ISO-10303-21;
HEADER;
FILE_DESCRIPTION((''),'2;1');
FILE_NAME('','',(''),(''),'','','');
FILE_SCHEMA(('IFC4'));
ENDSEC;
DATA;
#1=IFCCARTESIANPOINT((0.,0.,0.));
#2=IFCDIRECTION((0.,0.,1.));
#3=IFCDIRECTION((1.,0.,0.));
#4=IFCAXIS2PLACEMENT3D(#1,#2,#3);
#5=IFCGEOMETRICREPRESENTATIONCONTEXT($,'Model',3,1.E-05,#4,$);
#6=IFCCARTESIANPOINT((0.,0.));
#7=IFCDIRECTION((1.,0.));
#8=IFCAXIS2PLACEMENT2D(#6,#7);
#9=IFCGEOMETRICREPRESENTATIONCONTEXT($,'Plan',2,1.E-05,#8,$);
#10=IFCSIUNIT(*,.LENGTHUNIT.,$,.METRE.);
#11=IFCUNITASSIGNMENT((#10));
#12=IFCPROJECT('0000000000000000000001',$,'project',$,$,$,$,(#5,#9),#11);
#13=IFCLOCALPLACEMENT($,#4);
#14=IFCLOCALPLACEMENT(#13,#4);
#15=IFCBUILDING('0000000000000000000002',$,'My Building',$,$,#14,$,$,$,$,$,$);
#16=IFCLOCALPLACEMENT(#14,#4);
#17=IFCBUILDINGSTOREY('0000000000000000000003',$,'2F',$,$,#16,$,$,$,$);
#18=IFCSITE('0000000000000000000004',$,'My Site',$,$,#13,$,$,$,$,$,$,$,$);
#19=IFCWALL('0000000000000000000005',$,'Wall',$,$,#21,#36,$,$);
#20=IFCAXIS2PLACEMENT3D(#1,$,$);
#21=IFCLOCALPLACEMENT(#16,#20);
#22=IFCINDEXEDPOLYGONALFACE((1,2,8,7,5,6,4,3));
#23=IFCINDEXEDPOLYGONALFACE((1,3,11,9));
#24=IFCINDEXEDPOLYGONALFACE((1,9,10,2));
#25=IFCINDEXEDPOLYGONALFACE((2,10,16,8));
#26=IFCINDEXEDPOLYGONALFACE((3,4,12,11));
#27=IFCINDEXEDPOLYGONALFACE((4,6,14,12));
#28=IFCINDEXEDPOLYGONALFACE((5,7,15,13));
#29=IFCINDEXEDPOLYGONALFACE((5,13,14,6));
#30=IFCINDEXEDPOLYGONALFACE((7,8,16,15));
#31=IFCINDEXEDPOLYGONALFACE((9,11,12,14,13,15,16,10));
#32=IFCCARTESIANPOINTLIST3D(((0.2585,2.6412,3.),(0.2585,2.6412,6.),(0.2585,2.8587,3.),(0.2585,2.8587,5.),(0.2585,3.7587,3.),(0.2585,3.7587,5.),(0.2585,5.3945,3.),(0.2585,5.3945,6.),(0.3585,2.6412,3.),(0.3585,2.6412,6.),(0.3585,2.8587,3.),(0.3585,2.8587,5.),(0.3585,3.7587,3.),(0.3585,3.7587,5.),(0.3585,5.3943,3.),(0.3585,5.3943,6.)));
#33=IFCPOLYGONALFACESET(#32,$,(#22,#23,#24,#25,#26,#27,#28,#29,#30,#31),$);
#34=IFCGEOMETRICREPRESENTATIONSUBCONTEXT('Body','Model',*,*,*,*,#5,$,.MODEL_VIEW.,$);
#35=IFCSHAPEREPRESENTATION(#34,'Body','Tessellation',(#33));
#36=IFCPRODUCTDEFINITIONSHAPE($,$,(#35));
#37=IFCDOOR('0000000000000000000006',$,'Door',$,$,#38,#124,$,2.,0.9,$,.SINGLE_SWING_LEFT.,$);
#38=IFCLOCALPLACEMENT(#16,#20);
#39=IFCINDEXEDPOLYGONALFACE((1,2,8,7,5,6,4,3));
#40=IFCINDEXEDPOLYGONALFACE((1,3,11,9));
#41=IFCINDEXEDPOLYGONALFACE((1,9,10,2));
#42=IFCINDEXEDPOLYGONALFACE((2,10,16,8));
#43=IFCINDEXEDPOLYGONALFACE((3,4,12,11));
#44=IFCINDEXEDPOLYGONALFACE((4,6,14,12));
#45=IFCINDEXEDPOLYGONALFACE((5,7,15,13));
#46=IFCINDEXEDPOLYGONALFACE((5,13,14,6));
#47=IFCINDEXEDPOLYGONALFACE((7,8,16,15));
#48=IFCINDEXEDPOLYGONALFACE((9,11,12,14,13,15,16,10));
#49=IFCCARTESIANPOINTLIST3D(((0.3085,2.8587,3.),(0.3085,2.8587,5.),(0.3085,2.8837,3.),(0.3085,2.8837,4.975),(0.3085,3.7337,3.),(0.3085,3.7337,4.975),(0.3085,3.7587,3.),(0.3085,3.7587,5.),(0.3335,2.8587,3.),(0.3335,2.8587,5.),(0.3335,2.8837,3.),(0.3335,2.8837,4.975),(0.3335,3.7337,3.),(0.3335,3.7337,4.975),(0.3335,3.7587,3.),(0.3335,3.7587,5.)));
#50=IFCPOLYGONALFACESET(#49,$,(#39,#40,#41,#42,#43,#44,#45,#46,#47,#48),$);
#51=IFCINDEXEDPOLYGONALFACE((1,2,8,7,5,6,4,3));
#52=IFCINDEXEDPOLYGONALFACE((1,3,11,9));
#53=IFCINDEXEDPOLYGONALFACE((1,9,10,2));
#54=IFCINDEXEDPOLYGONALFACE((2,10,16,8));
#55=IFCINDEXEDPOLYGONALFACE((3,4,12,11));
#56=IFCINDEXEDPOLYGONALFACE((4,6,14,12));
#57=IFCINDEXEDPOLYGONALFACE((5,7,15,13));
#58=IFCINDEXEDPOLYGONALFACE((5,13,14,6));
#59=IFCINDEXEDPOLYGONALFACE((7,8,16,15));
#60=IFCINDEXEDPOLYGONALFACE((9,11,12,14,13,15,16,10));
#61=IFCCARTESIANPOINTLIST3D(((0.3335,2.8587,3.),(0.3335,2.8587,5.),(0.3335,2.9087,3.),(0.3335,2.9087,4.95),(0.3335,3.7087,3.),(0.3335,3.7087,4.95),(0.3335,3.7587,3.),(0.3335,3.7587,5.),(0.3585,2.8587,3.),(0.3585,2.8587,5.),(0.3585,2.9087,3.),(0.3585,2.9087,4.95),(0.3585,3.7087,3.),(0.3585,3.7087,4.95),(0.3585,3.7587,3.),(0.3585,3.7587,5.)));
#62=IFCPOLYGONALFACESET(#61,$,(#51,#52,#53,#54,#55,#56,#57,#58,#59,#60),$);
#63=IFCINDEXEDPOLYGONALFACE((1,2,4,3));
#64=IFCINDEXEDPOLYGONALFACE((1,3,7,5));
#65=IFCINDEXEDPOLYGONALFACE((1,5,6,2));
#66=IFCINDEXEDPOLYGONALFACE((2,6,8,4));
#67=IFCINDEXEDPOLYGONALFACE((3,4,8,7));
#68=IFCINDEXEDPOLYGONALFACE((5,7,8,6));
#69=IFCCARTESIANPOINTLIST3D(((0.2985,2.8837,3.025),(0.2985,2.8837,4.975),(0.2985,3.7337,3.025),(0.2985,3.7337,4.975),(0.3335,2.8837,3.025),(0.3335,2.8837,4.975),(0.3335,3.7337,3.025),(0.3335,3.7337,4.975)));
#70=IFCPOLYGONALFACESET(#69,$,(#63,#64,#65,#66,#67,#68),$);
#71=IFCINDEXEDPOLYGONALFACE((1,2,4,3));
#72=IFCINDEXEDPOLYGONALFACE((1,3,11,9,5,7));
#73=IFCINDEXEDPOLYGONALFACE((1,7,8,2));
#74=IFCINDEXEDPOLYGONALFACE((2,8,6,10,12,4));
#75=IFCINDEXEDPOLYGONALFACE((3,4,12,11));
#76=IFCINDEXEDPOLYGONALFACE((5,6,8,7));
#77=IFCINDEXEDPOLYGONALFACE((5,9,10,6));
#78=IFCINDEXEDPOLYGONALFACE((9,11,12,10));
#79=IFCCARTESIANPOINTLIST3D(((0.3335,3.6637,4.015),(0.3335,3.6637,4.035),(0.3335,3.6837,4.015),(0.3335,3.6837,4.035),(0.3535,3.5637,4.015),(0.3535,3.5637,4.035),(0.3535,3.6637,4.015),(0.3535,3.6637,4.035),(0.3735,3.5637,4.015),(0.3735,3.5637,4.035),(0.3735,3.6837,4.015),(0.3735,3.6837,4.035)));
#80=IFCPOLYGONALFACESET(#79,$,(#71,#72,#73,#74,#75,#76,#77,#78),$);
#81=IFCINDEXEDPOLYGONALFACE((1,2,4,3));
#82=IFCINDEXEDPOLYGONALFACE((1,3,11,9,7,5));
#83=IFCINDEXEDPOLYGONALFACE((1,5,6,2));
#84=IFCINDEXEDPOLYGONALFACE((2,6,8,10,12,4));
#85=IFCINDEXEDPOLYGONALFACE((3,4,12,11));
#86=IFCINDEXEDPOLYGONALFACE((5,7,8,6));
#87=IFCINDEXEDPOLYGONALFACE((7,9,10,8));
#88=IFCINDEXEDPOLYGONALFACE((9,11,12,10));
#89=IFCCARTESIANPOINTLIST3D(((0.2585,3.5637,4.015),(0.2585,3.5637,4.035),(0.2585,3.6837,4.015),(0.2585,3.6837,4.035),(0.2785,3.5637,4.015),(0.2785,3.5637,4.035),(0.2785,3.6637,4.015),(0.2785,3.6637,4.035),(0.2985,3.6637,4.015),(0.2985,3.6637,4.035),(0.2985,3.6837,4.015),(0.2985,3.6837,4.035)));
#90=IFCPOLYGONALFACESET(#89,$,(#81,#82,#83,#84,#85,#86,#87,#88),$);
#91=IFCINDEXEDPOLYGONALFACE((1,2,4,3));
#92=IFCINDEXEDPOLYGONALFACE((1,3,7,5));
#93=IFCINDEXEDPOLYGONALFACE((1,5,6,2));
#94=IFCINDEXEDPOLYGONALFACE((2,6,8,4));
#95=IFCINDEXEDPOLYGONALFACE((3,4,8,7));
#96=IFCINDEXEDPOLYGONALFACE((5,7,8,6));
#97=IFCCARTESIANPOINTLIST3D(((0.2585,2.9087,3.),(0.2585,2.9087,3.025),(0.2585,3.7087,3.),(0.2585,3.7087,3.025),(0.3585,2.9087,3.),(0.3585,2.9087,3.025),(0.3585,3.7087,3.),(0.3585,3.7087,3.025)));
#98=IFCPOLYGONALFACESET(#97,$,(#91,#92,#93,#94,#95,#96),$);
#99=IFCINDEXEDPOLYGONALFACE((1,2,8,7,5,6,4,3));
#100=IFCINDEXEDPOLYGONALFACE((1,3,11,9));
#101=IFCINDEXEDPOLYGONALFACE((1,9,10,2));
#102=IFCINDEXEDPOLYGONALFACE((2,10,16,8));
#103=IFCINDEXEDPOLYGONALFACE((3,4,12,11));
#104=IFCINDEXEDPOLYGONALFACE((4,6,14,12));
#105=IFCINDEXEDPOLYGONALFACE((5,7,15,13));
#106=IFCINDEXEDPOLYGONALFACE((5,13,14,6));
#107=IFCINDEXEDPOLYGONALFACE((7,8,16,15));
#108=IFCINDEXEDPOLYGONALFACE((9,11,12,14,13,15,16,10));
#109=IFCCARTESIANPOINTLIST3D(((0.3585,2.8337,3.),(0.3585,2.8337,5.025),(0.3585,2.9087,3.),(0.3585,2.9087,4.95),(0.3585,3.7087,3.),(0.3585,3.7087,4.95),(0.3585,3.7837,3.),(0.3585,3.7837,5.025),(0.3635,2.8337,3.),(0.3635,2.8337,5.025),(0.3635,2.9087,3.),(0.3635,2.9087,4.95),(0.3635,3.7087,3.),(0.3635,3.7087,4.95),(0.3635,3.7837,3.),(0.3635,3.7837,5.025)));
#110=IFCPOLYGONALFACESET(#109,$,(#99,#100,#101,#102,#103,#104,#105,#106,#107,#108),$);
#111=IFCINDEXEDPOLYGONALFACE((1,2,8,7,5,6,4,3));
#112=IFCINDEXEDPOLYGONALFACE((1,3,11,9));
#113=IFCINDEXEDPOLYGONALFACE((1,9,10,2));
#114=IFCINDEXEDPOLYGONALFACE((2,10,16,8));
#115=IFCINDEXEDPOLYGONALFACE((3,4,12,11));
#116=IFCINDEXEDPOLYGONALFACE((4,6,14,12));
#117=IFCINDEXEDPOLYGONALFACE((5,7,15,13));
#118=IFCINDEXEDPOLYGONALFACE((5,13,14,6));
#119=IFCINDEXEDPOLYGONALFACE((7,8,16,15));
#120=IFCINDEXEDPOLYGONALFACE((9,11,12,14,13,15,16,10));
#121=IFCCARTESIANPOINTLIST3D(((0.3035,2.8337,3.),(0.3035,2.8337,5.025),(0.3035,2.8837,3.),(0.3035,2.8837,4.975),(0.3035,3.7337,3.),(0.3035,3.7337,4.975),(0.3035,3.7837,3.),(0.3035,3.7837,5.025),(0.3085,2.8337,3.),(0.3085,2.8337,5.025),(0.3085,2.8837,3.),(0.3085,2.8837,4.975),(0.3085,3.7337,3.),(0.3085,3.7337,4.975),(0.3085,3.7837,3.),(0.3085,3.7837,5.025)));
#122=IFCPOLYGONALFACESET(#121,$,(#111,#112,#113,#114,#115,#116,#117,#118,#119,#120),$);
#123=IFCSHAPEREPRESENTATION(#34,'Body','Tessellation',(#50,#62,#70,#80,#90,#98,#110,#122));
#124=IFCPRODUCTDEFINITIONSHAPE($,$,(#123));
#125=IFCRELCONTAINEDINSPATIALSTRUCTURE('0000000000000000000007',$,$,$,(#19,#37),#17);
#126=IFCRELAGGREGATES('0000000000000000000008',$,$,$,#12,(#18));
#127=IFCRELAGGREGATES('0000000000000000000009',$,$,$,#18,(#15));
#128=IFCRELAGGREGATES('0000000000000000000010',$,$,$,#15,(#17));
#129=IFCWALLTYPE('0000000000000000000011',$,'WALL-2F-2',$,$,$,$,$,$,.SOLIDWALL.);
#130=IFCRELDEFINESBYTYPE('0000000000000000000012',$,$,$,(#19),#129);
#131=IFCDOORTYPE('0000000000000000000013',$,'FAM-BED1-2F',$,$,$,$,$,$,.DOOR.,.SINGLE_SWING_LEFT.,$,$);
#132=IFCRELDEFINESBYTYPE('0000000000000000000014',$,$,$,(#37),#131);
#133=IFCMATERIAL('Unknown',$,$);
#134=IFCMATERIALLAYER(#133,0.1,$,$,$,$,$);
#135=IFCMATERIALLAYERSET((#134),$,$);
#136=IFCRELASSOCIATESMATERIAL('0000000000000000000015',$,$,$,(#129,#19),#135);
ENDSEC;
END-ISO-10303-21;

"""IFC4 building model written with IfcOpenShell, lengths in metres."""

from ifc_helpers import new_model, entity, si_unit, frame, origin_with_axes, origin_2d_with_axis, place, context, subcontext, project, spatial, line, indexed_curve, outline, extrude, shape, source, transform, mapped, material, layer, layer_set, layer_usage, type_object, type_shapes, element, fill, save


model = new_model("IFC4")

# Units and contexts
model_context = context("Model", 3, precision=1e-05, world=origin_with_axes())
plan_context = context("Plan", 2, precision=1e-05, world=origin_2d_with_axis())
body_context_1 = subcontext(model_context, "Body", "Model", "MODEL_VIEW")
body_context_2 = subcontext(plan_context, "Body", "Plan", "PLAN_VIEW")
ifc_project = project(units=[si_unit("LENGTHUNIT", "METRE")], contexts=[model_context, plan_context])

# Site, building, storey
site_placement = place(None, origin_with_axes())
site = spatial("IfcSite", under=ifc_project, at=site_placement, Name="My Site")
building_placement = place(site_placement, origin_with_axes())
building = spatial("IfcBuilding", under=site, at=building_placement, Name="My Building")
storey_placement = place(building_placement, origin_with_axes())
storey = spatial("IfcBuildingStorey", under=building, at=storey_placement, Name="2F")

# Shared definitions
ifc_material = material(Name="Unknown")

# Wall, opening, door
ifc_layer_1 = layer(ifc_material, 0.1)
ifc_layer_set_1 = layer_set([ifc_layer_1])
ifc_layer_usage_1 = layer_usage(ifc_layer_set_1, "AXIS2", "POSITIVE", 0.0)
wall_type_1 = type_object("IfcWallType", Name="WALL-2F-2", PredefinedType="SOLIDWALL", material=ifc_layer_set_1)
wall_1_placement = place(storey_placement, frame((0.2585, 5.5445, 3.0), z_axis=(0.0, 0.0, 1.0), x_axis=(0.0, -1.0, 0.0)))
wall_1 = element("IfcWall", 1, at=wall_1_placement, inside=storey, type_object=wall_type_1, material=ifc_layer_usage_1, Name="Wall", context=body_context_1, shape_type="SweptSolid", body=[
    extrude(outline(indexed_curve([(0.15, 0.0), (0.1502, 0.1), (2.9032, 0.1), (2.9032, 0.0)], segments=[line(1, 2, 3, 4, 1)])), origin_with_axes(), (0.0, 0.0, 1.0), 3.0),
])
shared_shape_1 = source(origin_with_axes(), body_context_1, "Body", "SweptSolid", [
    extrude(outline(indexed_curve([(0.0, 0.0), (0.9, 0.0), (0.9, 2.0), (0.0, 2.0)], segments=[line(1, 2, 3, 4, 1)])), frame((0.0, -0.6, 0.0), z_axis=(0.0, -1.0, 0.0), x_axis=(1.0, 0.0, 0.0)), (0.0, 0.0, -1.0), 1.2),
])
opening_1_placement = place(wall_1_placement, frame((2.6858, 0.1, 0.0), z_axis=(0.0, 0.0, 1.0), x_axis=(-1.0, 0.0, 0.0)))
opening_1 = element("IfcOpeningElement", 2, at=opening_1_placement, cuts=wall_1, PredefinedType="OPENING", context=body_context_1, shape_type="MappedRepresentation", body=[
    mapped(shared_shape_1, transform((0.0, 0.0, 0.0), x_axis=(1.0, 0.0, 0.0), y_axis=(0.0, 1.0, 0.0), z_axis=(0.0, 0.0, 1.0), scale=1.0)),
])
door_type_1 = type_object("IfcDoorType", Name="FAM-BED1-2F", OperationType="SINGLE_SWING_LEFT", PredefinedType="DOOR")
shared_shape_2 = source(origin_with_axes(), body_context_1, "Body", "SweptSolid", [
    extrude(outline(indexed_curve([(0.0, 0.0), (0.0, 2.0), (0.9, 2.0), (0.9, 0.0), (0.875, 0.0), (0.875, 1.975), (0.025, 1.975), (0.025, 0.0)], segments=[line(1, 2, 3, 4, 5, 6, 7, 8, 1)])), frame((0.0, 0.025, 0.0), z_axis=(0.0, -1.0, 0.0), x_axis=(1.0, 0.0, 0.0)), (0.0, 0.0, -1.0), 0.025),
    extrude(outline(indexed_curve([(0.0, 0.0), (0.0, 2.0), (0.9, 2.0), (0.9, 0.0), (0.85, 0.0), (0.85, 1.95), (0.05, 1.95), (0.05, 0.0)], segments=[line(1, 2, 3, 4, 5, 6, 7, 8, 1)])), frame((0.0, 0.0, 0.0), z_axis=(0.0, -1.0, 0.0), x_axis=(1.0, 0.0, 0.0)), (0.0, 0.0, -1.0), 0.025),
    extrude(outline(indexed_curve([(0.0, 0.0), (0.85, 0.0), (0.85, 0.035), (0.0, 0.035)], segments=[line(1, 2, 3, 4, 1)])), frame((0.025, 0.025, 0.025), z_axis=(0.0, 0.0, 1.0), x_axis=(1.0, 0.0, 0.0)), (0.0, 0.0, 1.0), 1.95),
    extrude(outline(indexed_curve([(0.0, 0.0), (0.0, -0.04), (-0.12, -0.04), (-0.12, -0.02), (-0.02, -0.02), (-0.02, 0.0)], segments=[line(1, 2, 3, 4, 5, 6, 1)])), frame((0.825, 0.025, 1.015), z_axis=(0.0, 0.0, 1.0), x_axis=(1.0, 0.0, 0.0)), (0.0, 0.0, 1.0), 0.02),
    extrude(outline(indexed_curve([(0.0, 0.0), (0.0, 0.04), (-0.12, 0.04), (-0.12, 0.02), (-0.02, 0.02), (-0.02, 0.0)], segments=[line(1, 2, 3, 4, 5, 6, 1)])), frame((0.825, 0.06, 1.015), z_axis=(0.0, 0.0, 1.0), x_axis=(1.0, 0.0, 0.0)), (0.0, 0.0, 1.0), 0.02),
    extrude(outline(indexed_curve([(0.0, 0.0), (0.8, 0.0), (0.8, 0.1), (0.0, 0.1)], segments=[line(1, 2, 3, 4, 1)])), frame((0.05, 0.0, 0.0), z_axis=(0.0, 0.0, 1.0), x_axis=(1.0, 0.0, 0.0)), (0.0, 0.0, 1.0), 0.025),
    extrude(outline(indexed_curve([(0.0, 0.0), (0.0, 2.025), (0.95, 2.025), (0.95, 0.0), (0.875, 0.0), (0.875, 1.95), (0.075, 1.95), (0.075, 0.0)], segments=[line(1, 2, 3, 4, 5, 6, 7, 8, 1)])), frame((-0.025, -0.005, 0.0), z_axis=(0.0, -1.0, 0.0), x_axis=(1.0, 0.0, 0.0)), (0.0, 0.0, -1.0), 0.005),
    extrude(outline(indexed_curve([(0.0, 0.0), (0.0, 2.025), (0.95, 2.025), (0.95, 0.0), (0.9, 0.0), (0.9, 1.975), (0.05, 1.975), (0.05, 0.0)], segments=[line(1, 2, 3, 4, 5, 6, 7, 8, 1)])), frame((-0.025, 0.05, 0.0), z_axis=(0.0, -1.0, 0.0), x_axis=(1.0, 0.0, 0.0)), (0.0, 0.0, -1.0), 0.005),
])
shared_shape_3 = source(origin_with_axes(), body_context_2, "Body", "Curve2D", [
    entity("IfcIndexedPolyCurve", entity("IfcCartesianPointList2D", [[0.0, 0.0], [0.0, 0.05], [0.025, 0.05], [0.025, 0.025], [0.05, 0.025], [0.05, 0.0]]), [entity("IfcLineIndex", [1, 2, 3, 4, 5, 6, 1])]),
    entity("IfcIndexedPolyCurve", entity("IfcCartesianPointList2D", [[0.9, 0.0], [0.9, 0.05], [0.875, 0.05], [0.875, 0.025], [0.85, 0.025], [0.85, 0.0]]), [entity("IfcLineIndex", [1, 2, 3, 4, 5, 6, 1])]),
    entity("IfcTrimmedCurve", entity("IfcEllipse", entity("IfcAxis2Placement2D", entity("IfcCartesianPoint", [0.06, 0.05]), entity("IfcDirection", [1.0, 0.0])), 0.815, 0.85), [entity("IfcCartesianPoint", [0.875, 0.05])], [entity("IfcCartesianPoint", [0.06, 0.9])], True, "CARTESIAN"),
    entity("IfcIndexedPolyCurve", entity("IfcCartesianPointList2D", [[0.025, 0.05], [0.06, 0.05], [0.06, 0.9], [0.025, 0.9]]), [entity("IfcLineIndex", [1, 2, 3, 4, 1])]),
])
type_shapes(door_type_1, [shared_shape_2, shared_shape_3])
door_1_placement = place(opening_1_placement, frame((0.0, 0.0, 0.0), z_axis=(0.0, 0.0, 1.0), x_axis=(1.0, 0.0, 0.0)))
door_1 = element("IfcDoor", 3, at=door_1_placement, inside=storey, type_object=door_type_1, Name="Door", OperationType="SINGLE_SWING_LEFT", OverallHeight=2.0, OverallWidth=0.9, shapes=[
    shape(body_context_1, "Body", "MappedRepresentation", [mapped(shared_shape_2, transform((0.0, 0.0, 0.0), x_axis=(1.0, 0.0, 0.0), y_axis=(0.0, 1.0, 0.0), z_axis=(0.0, 0.0, 1.0), scale=1.0))]),
    shape(body_context_2, "Body", "MappedRepresentation", [mapped(shared_shape_3, transform((0.0, 0.0, 0.0), x_axis=(1.0, 0.0, 0.0), y_axis=(0.0, 1.0, 0.0), z_axis=(0.0, 0.0, 1.0), scale=1.0))]),
])
fill(opening_1, door_1)

save(model, "model.ifc")
